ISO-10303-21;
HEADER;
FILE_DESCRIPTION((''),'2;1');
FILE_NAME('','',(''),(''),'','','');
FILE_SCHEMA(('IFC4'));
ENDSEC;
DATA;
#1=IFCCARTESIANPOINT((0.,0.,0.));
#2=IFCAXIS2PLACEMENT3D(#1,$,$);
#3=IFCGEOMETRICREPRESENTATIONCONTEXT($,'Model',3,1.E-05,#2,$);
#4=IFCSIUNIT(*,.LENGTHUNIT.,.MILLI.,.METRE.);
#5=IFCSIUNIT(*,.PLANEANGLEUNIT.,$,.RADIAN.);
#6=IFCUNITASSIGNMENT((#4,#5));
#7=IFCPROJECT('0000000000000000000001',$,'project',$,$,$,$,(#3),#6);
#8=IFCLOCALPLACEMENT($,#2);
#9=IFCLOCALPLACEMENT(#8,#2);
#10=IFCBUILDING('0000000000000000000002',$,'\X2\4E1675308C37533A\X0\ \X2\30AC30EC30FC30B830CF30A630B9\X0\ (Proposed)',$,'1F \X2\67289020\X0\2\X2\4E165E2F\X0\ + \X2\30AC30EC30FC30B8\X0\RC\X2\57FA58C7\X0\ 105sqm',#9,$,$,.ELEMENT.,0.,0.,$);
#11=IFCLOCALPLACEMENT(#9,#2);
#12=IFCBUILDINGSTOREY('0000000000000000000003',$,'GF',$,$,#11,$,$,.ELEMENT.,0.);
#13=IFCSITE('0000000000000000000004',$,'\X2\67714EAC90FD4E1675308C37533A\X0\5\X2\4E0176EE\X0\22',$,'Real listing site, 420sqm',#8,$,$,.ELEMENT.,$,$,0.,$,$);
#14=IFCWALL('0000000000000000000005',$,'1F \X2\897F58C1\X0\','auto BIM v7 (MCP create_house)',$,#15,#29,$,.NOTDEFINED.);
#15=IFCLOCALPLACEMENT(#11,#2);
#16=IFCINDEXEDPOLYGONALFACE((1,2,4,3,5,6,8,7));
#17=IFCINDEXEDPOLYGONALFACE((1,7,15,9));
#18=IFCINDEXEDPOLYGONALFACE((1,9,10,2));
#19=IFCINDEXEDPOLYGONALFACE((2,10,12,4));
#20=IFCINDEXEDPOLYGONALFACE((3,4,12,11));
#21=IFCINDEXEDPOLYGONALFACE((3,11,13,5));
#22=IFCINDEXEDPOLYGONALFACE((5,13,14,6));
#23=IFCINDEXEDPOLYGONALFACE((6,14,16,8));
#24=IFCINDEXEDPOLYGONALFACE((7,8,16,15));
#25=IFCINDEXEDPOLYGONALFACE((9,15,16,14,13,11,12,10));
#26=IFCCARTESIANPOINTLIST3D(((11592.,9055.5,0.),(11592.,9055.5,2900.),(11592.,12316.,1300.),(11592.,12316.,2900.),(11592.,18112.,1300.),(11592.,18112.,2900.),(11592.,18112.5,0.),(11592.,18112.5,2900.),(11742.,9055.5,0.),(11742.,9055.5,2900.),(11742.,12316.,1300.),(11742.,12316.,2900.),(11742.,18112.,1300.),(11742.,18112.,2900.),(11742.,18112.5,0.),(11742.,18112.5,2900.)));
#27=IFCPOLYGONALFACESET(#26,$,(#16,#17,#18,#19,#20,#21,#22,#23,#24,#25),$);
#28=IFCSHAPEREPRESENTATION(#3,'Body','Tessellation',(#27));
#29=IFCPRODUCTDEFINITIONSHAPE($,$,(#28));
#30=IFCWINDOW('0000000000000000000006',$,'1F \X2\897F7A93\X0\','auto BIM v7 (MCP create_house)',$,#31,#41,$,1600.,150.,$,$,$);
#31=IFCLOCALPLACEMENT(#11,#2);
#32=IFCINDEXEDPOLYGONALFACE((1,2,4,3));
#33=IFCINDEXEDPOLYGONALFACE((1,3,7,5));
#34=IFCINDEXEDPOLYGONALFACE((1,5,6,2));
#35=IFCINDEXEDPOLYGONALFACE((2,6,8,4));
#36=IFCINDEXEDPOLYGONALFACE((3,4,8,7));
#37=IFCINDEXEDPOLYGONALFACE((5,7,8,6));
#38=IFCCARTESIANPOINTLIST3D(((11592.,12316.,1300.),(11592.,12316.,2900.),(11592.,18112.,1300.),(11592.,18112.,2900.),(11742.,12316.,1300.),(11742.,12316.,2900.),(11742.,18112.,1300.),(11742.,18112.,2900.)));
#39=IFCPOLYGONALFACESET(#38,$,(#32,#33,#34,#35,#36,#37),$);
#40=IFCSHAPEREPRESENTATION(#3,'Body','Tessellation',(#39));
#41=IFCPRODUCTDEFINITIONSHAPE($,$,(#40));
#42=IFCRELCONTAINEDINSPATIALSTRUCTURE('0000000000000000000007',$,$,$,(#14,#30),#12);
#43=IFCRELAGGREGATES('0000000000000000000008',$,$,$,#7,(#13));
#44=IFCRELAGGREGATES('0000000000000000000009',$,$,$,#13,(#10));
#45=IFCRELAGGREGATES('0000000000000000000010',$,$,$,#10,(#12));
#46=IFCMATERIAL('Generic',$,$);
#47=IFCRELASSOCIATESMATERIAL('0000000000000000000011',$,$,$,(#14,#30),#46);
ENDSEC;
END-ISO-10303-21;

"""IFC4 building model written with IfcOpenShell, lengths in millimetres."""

from ifc_helpers import new_model, si_unit, frame, frame_2d, origin, place, context, project, spatial, rectangle, extrude, material, element, fill, save


model = new_model("IFC4")

# Units and contexts
model_context = context("Model", 3, precision=1e-05, world=origin())
ifc_project = project(units=[si_unit("LENGTHUNIT", "METRE", prefix="MILLI"), si_unit("PLANEANGLEUNIT", "RADIAN")], contexts=[model_context])

# Site, building, storey
site_placement = place(None, origin())
site = spatial("IfcSite", under=ifc_project, at=site_placement, Name="東京都世田谷区5丁目22", ObjectType="Real listing site, 420sqm", CompositionType="ELEMENT", RefElevation=0.0)
building_placement = place(site_placement, origin())
building = spatial("IfcBuilding", under=site, at=building_placement, Name="世田谷区 ガレージハウス (Proposed)", ObjectType="1F 木造2世帯 + ガレージRC基壇 105sqm", CompositionType="ELEMENT", ElevationOfRefHeight=0.0, ElevationOfTerrain=0.0)
storey_placement = place(building_placement, origin())
storey = spatial("IfcBuildingStorey", under=building, at=storey_placement, Name="GF", CompositionType="ELEMENT", Elevation=0.0)

# Shared definitions
ifc_material = material(Name="Generic")

# Wall, opening, window
wall_1_placement = place(storey_placement, frame((5796.0, 4528.0, 0.0)))
wall_1 = element("IfcWall", 1, at=wall_1_placement, inside=storey, material=ifc_material, Name="1F 西壁", Description="auto BIM v7 (MCP create_house)", PredefinedType="NOTDEFINED", context=model_context, shape_type="SweptSolid", body=[
    extrude(rectangle(XDim=150.0, YDim=9057.0, at=frame_2d((75.0, 4528.0))), frame((5796.0, 4528.0, 0.0)), (0.0, 0.0, 1.0), 2900.0),
])
opening_1_placement = place(storey_placement, frame((5796.0, 6158.0, 650.0)))
opening_1 = element("IfcOpeningElement", 2, at=opening_1_placement, cuts=wall_1, PredefinedType="NOTDEFINED", context=model_context, shape_type="SweptSolid", body=[
    extrude(rectangle(XDim=150.0, YDim=5796.0, at=frame_2d((75.0, 2898.0))), frame((5796.0, 6158.0, 650.0)), (0.0, 0.0, 1.0), 1600.0),
])
window_1_placement = place(storey_placement, frame((5796.0, 6158.0, 650.0)))
window_1 = element("IfcWindow", 3, at=window_1_placement, inside=storey, material=ifc_material, Name="1F 西窓", Description="auto BIM v7 (MCP create_house)", OverallHeight=1600.0, OverallWidth=150.0, context=model_context, shape_type="SweptSolid", body=[
    extrude(rectangle(XDim=150.0, YDim=5796.0, at=frame_2d((75.0, 2898.0))), frame((5796.0, 6158.0, 650.0)), (0.0, 0.0, 1.0), 1600.0),
])
fill(opening_1, window_1)

save(model, "model.ifc")
